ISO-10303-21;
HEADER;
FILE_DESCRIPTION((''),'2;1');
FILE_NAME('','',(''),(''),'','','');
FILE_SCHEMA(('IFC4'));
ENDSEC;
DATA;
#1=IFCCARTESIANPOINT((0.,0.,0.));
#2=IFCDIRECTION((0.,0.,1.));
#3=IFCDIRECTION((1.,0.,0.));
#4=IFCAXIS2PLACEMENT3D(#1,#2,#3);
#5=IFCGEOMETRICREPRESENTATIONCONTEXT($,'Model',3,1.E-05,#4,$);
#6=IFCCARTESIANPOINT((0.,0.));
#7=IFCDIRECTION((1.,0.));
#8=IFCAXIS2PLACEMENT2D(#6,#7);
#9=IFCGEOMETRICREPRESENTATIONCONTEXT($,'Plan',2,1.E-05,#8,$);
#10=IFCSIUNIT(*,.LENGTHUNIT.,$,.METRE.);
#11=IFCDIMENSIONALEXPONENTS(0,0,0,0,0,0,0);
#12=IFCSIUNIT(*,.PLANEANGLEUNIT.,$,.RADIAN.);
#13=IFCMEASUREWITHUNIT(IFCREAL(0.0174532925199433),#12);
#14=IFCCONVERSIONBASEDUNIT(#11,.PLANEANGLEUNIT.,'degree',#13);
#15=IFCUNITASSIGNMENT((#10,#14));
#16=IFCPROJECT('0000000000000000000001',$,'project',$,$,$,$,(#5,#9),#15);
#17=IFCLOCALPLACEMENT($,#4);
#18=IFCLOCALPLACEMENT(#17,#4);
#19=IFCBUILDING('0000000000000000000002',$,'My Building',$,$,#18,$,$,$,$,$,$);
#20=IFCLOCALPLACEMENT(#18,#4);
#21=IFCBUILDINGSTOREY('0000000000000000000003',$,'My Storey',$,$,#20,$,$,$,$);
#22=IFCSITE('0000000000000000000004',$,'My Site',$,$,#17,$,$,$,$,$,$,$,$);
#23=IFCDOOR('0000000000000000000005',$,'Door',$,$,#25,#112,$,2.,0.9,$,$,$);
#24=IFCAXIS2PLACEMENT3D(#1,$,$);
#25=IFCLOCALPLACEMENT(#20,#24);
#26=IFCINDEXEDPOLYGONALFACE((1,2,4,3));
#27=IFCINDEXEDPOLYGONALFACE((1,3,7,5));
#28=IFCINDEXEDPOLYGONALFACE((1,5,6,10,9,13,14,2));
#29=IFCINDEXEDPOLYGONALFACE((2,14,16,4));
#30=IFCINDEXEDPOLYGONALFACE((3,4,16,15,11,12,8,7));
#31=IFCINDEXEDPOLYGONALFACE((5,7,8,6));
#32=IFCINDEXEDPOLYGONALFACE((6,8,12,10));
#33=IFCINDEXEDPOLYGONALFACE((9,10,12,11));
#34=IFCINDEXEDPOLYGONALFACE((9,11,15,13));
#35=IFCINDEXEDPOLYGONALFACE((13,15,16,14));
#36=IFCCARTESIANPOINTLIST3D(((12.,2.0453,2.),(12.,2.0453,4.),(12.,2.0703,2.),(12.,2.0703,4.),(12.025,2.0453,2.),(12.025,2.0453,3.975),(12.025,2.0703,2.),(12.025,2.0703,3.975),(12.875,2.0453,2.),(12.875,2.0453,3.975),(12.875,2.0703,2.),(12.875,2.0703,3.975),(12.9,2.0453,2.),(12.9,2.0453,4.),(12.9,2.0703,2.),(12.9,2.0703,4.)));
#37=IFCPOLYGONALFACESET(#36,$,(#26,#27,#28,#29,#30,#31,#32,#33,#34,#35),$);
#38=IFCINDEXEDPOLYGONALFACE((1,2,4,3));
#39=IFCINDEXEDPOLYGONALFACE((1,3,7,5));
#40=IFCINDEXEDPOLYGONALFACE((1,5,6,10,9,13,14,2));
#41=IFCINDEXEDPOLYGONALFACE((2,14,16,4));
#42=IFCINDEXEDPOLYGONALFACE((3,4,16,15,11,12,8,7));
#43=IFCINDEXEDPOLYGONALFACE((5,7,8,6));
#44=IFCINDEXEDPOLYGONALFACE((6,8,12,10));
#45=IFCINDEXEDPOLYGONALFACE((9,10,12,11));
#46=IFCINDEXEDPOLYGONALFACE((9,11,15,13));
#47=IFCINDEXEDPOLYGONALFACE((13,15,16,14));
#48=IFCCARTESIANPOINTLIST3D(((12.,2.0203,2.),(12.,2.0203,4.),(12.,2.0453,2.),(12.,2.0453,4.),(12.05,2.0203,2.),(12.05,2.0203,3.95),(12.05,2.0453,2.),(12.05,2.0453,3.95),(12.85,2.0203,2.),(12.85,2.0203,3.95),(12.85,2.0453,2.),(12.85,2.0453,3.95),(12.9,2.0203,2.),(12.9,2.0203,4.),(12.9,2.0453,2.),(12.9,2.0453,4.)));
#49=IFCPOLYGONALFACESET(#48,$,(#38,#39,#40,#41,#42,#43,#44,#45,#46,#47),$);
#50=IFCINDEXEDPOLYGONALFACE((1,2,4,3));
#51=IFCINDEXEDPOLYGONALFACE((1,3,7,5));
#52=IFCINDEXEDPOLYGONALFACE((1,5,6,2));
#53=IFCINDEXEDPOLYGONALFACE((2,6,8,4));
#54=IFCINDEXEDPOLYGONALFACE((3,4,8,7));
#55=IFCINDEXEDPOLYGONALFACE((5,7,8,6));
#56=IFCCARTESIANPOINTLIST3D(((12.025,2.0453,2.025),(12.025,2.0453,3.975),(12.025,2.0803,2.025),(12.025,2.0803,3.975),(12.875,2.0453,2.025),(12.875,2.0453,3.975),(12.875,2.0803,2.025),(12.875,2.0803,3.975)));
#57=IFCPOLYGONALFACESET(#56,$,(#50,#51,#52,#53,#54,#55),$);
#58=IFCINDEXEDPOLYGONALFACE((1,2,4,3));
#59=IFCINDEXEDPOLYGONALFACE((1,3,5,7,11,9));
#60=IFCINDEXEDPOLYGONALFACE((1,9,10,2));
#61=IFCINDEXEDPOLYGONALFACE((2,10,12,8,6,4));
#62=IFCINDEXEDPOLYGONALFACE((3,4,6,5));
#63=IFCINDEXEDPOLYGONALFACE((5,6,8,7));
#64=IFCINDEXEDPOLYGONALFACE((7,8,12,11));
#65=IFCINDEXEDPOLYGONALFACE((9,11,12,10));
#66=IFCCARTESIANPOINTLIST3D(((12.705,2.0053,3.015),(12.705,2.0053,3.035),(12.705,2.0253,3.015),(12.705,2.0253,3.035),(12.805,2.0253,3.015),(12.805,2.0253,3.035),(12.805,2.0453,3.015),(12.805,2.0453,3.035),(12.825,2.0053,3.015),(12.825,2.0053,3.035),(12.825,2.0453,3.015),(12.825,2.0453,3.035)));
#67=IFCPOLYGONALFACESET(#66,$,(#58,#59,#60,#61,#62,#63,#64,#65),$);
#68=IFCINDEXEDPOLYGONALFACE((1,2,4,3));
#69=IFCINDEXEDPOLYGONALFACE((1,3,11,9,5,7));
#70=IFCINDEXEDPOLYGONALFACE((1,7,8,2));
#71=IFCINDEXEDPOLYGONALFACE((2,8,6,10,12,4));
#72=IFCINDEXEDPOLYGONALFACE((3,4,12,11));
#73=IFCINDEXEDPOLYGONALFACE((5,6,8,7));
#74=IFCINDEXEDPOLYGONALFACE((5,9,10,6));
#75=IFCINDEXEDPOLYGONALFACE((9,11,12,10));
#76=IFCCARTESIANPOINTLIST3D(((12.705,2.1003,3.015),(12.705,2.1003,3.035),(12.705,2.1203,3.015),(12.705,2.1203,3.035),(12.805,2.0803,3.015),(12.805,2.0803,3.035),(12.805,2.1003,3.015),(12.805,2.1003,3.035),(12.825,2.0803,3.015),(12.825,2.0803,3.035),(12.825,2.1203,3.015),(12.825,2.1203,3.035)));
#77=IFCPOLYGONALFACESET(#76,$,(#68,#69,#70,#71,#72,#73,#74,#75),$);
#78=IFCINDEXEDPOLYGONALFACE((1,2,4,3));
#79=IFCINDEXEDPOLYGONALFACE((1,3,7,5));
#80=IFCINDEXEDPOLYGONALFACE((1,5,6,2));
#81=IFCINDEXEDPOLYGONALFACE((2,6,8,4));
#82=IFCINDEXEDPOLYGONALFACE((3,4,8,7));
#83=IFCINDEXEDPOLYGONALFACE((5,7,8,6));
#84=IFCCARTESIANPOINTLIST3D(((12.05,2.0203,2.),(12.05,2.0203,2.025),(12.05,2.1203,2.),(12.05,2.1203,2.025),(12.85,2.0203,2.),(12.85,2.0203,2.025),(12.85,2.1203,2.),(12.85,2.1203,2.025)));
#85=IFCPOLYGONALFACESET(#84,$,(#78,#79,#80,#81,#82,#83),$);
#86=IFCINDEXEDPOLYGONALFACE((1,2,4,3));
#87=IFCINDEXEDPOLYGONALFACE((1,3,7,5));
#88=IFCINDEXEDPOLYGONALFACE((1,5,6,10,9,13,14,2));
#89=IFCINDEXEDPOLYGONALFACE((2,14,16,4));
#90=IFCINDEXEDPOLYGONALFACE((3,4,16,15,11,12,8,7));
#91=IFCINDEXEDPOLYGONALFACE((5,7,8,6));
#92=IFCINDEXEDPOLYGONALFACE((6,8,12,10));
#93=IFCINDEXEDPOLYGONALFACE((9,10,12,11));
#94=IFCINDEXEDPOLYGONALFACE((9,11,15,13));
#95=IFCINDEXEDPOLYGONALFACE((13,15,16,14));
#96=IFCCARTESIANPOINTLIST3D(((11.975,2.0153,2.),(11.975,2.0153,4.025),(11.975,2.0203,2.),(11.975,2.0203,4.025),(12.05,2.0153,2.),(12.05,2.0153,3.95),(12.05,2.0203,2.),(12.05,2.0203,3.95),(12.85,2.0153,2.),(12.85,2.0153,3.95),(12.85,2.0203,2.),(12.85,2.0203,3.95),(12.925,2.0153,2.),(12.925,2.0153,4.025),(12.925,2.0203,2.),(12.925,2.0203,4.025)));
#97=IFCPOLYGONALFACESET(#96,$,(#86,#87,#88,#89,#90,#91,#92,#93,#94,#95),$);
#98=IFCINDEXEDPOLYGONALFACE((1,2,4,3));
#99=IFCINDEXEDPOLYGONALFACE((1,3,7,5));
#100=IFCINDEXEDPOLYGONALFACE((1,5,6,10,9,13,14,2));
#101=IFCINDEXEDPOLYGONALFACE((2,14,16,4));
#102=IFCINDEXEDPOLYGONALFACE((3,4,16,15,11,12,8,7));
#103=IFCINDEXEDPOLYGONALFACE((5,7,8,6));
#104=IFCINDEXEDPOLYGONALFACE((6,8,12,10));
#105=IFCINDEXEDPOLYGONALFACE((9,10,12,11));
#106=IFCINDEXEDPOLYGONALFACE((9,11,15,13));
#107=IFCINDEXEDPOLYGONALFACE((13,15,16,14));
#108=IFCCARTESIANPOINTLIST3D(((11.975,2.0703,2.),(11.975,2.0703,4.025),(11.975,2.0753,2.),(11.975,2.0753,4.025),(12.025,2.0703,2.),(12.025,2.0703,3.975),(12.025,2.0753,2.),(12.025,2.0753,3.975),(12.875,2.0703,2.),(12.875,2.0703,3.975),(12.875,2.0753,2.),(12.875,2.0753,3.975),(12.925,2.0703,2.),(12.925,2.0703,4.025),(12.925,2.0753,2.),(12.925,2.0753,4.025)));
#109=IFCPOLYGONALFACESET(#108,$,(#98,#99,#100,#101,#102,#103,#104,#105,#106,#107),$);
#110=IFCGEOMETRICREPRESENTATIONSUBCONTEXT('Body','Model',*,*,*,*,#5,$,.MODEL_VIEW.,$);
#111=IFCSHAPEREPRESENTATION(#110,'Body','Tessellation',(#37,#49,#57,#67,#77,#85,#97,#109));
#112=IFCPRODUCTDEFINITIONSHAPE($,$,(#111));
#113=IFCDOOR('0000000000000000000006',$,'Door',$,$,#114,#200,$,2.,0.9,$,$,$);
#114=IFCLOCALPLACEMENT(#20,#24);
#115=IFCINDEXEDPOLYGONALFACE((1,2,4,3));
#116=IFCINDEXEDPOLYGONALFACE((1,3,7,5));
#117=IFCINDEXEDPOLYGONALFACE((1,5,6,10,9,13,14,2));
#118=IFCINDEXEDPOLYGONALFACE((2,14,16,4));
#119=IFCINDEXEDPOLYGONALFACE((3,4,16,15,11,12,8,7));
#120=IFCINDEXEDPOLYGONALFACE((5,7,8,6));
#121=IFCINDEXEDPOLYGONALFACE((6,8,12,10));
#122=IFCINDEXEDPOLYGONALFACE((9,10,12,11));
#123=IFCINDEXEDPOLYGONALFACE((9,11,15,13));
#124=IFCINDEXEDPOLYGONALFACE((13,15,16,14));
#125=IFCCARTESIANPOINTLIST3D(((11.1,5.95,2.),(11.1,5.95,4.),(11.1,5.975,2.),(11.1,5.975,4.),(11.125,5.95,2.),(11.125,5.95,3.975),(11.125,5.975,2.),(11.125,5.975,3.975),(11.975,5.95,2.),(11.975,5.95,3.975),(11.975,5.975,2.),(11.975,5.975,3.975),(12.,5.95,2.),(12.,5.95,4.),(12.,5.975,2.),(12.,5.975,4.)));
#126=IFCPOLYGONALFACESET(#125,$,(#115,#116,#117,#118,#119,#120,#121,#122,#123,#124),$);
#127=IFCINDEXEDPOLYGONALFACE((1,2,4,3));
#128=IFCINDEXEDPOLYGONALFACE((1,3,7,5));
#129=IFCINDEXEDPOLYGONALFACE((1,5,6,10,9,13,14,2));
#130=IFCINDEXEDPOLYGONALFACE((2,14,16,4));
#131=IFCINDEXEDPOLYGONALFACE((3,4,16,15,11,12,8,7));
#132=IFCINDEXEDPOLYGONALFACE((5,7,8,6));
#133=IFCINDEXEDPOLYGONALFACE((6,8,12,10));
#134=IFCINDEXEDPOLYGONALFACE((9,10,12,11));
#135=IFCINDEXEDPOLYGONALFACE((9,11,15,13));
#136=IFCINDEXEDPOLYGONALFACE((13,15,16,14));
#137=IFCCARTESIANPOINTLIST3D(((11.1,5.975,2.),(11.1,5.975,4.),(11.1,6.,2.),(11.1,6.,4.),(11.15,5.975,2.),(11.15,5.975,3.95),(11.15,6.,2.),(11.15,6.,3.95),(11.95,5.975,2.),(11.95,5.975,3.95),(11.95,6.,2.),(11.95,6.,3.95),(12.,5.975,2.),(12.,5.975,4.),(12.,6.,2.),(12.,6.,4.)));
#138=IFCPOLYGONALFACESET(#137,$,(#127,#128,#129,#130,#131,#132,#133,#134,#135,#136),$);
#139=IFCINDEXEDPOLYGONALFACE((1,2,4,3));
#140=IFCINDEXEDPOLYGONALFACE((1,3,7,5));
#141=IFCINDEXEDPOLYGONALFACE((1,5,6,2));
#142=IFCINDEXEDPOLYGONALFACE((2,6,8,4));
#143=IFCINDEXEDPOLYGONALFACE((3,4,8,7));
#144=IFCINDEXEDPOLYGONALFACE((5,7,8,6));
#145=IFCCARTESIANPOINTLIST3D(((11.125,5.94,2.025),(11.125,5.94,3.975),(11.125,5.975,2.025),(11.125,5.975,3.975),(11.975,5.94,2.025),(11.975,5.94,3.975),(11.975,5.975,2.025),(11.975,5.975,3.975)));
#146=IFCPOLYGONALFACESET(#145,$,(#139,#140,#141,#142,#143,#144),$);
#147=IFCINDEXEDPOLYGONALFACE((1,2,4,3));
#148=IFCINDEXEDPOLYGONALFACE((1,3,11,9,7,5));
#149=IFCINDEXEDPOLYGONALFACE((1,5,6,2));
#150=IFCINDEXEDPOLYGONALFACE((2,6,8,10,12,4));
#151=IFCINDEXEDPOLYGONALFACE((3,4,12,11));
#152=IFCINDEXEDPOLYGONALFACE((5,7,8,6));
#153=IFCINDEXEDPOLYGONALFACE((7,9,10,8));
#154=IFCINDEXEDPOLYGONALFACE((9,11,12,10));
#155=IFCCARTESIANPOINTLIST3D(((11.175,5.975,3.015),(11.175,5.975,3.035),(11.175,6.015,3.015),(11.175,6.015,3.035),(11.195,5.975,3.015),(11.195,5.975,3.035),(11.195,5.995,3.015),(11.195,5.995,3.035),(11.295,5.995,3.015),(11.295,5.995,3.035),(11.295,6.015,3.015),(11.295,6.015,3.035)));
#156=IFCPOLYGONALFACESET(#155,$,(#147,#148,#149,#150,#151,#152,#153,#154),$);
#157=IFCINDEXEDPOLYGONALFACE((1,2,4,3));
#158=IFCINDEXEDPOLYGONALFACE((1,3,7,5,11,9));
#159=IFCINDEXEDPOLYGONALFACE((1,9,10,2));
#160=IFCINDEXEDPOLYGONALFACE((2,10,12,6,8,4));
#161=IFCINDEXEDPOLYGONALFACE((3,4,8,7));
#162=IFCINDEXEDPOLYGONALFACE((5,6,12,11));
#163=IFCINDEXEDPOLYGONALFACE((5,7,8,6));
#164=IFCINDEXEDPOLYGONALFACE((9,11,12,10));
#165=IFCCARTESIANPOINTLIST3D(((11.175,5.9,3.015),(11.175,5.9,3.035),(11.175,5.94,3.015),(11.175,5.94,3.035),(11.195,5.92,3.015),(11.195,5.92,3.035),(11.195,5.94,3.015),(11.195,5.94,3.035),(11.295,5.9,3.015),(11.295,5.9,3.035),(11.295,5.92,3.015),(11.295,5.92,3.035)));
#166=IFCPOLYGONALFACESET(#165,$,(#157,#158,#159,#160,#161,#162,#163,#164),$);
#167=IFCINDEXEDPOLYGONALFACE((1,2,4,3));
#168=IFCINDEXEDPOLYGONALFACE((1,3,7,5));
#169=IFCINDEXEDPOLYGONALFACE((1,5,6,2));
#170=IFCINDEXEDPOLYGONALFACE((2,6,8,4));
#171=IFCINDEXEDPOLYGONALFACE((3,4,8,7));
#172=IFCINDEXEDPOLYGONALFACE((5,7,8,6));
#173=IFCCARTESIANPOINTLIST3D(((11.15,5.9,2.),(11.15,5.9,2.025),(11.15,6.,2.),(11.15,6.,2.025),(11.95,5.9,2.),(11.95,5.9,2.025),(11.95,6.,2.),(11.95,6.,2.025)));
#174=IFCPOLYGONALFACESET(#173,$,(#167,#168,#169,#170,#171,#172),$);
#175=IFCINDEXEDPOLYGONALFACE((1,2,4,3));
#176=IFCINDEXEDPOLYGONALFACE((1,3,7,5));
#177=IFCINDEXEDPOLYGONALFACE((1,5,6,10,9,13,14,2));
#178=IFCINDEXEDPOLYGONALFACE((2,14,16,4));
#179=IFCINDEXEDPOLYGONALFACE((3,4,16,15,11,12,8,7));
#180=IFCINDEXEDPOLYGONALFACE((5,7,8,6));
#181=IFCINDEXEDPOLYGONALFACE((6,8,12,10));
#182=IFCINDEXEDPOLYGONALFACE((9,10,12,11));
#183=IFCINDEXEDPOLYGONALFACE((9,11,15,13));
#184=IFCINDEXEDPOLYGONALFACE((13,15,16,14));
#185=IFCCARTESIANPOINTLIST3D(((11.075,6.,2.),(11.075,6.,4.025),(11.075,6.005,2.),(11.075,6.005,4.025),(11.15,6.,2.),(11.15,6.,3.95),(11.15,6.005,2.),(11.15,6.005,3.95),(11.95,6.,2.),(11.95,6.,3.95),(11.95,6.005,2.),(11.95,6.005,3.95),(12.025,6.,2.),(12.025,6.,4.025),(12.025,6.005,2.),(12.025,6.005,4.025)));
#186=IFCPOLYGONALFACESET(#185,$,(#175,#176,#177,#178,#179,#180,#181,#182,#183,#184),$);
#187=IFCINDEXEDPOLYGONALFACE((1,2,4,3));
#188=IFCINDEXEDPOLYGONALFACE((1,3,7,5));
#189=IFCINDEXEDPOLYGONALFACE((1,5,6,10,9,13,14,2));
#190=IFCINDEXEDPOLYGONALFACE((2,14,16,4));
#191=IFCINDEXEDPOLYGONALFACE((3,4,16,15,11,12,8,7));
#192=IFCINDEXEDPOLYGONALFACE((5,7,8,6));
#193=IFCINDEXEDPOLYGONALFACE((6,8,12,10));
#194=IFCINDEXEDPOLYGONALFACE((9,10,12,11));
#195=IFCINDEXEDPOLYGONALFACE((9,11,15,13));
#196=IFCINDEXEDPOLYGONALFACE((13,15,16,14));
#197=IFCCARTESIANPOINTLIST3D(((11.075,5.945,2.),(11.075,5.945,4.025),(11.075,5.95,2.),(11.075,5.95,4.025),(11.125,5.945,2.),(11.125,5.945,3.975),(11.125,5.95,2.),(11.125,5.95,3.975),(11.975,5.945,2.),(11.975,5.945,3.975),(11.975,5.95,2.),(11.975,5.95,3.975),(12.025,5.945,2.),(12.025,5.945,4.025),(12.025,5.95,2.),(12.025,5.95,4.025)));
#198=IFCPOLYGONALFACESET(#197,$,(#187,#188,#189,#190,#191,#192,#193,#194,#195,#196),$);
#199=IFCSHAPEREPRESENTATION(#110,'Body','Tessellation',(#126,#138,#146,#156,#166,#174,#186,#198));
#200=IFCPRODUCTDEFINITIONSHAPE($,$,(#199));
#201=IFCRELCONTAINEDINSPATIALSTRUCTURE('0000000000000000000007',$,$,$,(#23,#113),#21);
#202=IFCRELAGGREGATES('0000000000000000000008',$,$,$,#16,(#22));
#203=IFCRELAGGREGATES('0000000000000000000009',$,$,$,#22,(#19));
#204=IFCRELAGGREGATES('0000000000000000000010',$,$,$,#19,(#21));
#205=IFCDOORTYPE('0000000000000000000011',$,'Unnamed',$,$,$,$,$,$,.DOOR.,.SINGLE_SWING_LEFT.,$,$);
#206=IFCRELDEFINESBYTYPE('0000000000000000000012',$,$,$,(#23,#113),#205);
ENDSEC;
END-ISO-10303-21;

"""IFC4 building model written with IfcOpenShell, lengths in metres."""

from ifc_helpers import new_model, entity, si_unit, converted_unit, frame, origin_with_axes, origin_2d_with_axis, place, context, subcontext, project, spatial, line, indexed_curve, outline, extrude, shape, source, transform, mapped, type_object, type_shapes, element, save


model = new_model("IFC4")

# Units and contexts
model_context = context("Model", 3, precision=1e-05, world=origin_with_axes())
plan_context = context("Plan", 2, precision=1e-05, world=origin_2d_with_axis())
body_context_1 = subcontext(model_context, "Body", "Model", "MODEL_VIEW")
body_context_2 = subcontext(plan_context, "Body", "Plan", "PLAN_VIEW")
ifc_project = project(units=[si_unit("LENGTHUNIT", "METRE"), converted_unit("PLANEANGLEUNIT", "degree", entity("IfcReal", 0.0174532925199433), si_unit("PLANEANGLEUNIT", "RADIAN"), dimensions=[0, 0, 0, 0, 0, 0, 0])], contexts=[model_context, plan_context])

# Site, building, storey
site_placement = place(None, origin_with_axes())
site = spatial("IfcSite", under=ifc_project, at=site_placement, Name="My Site")
building_placement = place(site_placement, origin_with_axes())
building = spatial("IfcBuilding", under=site, at=building_placement, Name="My Building")
storey_placement = place(building_placement, origin_with_axes())
storey = spatial("IfcBuildingStorey", under=building, at=storey_placement, Name="My Storey")

# Doors
door_type = type_object("IfcDoorType", Name="Unnamed", OperationType="SINGLE_SWING_LEFT", PredefinedType="DOOR")
shared_shape_1 = source(origin_with_axes(), body_context_1, "Body", "SolidModel", [
    extrude(outline(indexed_curve([(0.0, 0.0), (0.0, 2.0), (0.9, 2.0), (0.9, 0.0), (0.875, 0.0), (0.875, 1.975), (0.025, 1.975), (0.025, 0.0)], segments=[line(1, 2, 3, 4, 5, 6, 7, 8, 1)])), frame((0.0, 0.025, 0.0), z_axis=(0.0, -1.0, 0.0), x_axis=(1.0, 0.0, 0.0)), (0.0, 0.0, -1.0), 0.025),
    extrude(outline(indexed_curve([(0.0, 0.0), (0.0, 2.0), (0.9, 2.0), (0.9, 0.0), (0.85, 0.0), (0.85, 1.95), (0.05, 1.95), (0.05, 0.0)], segments=[line(1, 2, 3, 4, 5, 6, 7, 8, 1)])), frame((0.0, 0.0, 0.0), z_axis=(0.0, -1.0, 0.0), x_axis=(1.0, 0.0, 0.0)), (0.0, 0.0, -1.0), 0.025),
    extrude(outline(indexed_curve([(0.0, 0.0), (0.85, 0.0), (0.85, 0.035), (0.0, 0.035)], segments=[line(1, 2, 3, 4, 1)])), frame((0.025, 0.025, 0.025), z_axis=(0.0, 0.0, 1.0), x_axis=(1.0, 0.0, 0.0)), (0.0, 0.0, 1.0), 1.95),
    extrude(outline(indexed_curve([(0.0, 0.0), (0.0, -0.04), (-0.12, -0.04), (-0.12, -0.02), (-0.02, -0.02), (-0.02, 0.0)], segments=[line(1, 2, 3, 4, 5, 6, 1)])), frame((0.825, 0.025, 1.015), z_axis=(0.0, 0.0, 1.0), x_axis=(1.0, 0.0, 0.0)), (0.0, 0.0, 1.0), 0.02),
    extrude(outline(indexed_curve([(0.0, 0.0), (0.0, 0.04), (-0.12, 0.04), (-0.12, 0.02), (-0.02, 0.02), (-0.02, 0.0)], segments=[line(1, 2, 3, 4, 5, 6, 1)])), frame((0.825, 0.06, 1.015), z_axis=(0.0, 0.0, 1.0), x_axis=(1.0, 0.0, 0.0)), (0.0, 0.0, 1.0), 0.02),
    extrude(outline(indexed_curve([(0.0, 0.0), (0.8, 0.0), (0.8, 0.1), (0.0, 0.1)], segments=[line(1, 2, 3, 4, 1)])), frame((0.05, 0.0, 0.0), z_axis=(0.0, 0.0, 1.0), x_axis=(1.0, 0.0, 0.0)), (0.0, 0.0, 1.0), 0.025),
    extrude(outline(indexed_curve([(0.0, 0.0), (0.0, 2.025), (0.95, 2.025), (0.95, 0.0), (0.875, 0.0), (0.875, 1.95), (0.075, 1.95), (0.075, 0.0)], segments=[line(1, 2, 3, 4, 5, 6, 7, 8, 1)])), frame((-0.025, -0.005, 0.0), z_axis=(0.0, -1.0, 0.0), x_axis=(1.0, 0.0, 0.0)), (0.0, 0.0, -1.0), 0.005),
    extrude(outline(indexed_curve([(0.0, 0.0), (0.0, 2.025), (0.95, 2.025), (0.95, 0.0), (0.9, 0.0), (0.9, 1.975), (0.05, 1.975), (0.05, 0.0)], segments=[line(1, 2, 3, 4, 5, 6, 7, 8, 1)])), frame((-0.025, 0.05, 0.0), z_axis=(0.0, -1.0, 0.0), x_axis=(1.0, 0.0, 0.0)), (0.0, 0.0, -1.0), 0.005),
])
shared_shape_2 = source(origin_with_axes(), body_context_2, "Body", "Curve2D", [
    entity("IfcIndexedPolyCurve", entity("IfcCartesianPointList2D", [[0.0, 0.0], [0.0, 0.05], [0.025, 0.05], [0.025, 0.025], [0.05, 0.025], [0.05, 0.0]]), [entity("IfcLineIndex", [1, 2, 3, 4, 5, 6, 1])]),
    entity("IfcIndexedPolyCurve", entity("IfcCartesianPointList2D", [[0.9, 0.0], [0.9, 0.05], [0.875, 0.05], [0.875, 0.025], [0.85, 0.025], [0.85, 0.0]]), [entity("IfcLineIndex", [1, 2, 3, 4, 5, 6, 1])]),
    entity("IfcTrimmedCurve", entity("IfcEllipse", entity("IfcAxis2Placement2D", entity("IfcCartesianPoint", [0.06, 0.05]), entity("IfcDirection", [1.0, 0.0])), 0.815, 0.85), [entity("IfcCartesianPoint", [0.875, 0.05])], [entity("IfcCartesianPoint", [0.06, 0.9])], True, "CARTESIAN"),
    entity("IfcIndexedPolyCurve", entity("IfcCartesianPointList2D", [[0.025, 0.05], [0.06, 0.05], [0.06, 0.9], [0.025, 0.9]]), [entity("IfcLineIndex", [1, 2, 3, 4, 1])]),
])
type_shapes(door_type, [shared_shape_1, shared_shape_2])
for number, where, z_axis, x_axis, name in (
    (1, (12.0, 2.0203, 2.0), (0.0, 0.0, 1.0), (1.0, 0.0, 0.0), "Door"),
    (2, (12.0, 6.0, 2.0), (0.0, 0.0, 1.0), (-1.0, 0.0, 0.0), "Door"),
):
    element("IfcDoor", number, at=place(storey_placement, frame(where, z_axis=z_axis, x_axis=x_axis)), inside=storey, type_object=door_type, Name=name, OverallHeight=2.0, OverallWidth=0.9, shapes=[
        shape(body_context_1, "Body", "MappedRepresentation", [mapped(shared_shape_1, transform((0.0, 0.0, 0.0), x_axis=(1.0, 0.0, 0.0), y_axis=(0.0, 1.0, 0.0), z_axis=(0.0, 0.0, 1.0), scale=1.0))]),
        shape(body_context_2, "Body", "MappedRepresentation", [mapped(shared_shape_2, transform((0.0, 0.0, 0.0), x_axis=(1.0, 0.0, 0.0), y_axis=(0.0, 1.0, 0.0), z_axis=(0.0, 0.0, 1.0), scale=1.0))]),
    ])

save(model, "model.ifc")
